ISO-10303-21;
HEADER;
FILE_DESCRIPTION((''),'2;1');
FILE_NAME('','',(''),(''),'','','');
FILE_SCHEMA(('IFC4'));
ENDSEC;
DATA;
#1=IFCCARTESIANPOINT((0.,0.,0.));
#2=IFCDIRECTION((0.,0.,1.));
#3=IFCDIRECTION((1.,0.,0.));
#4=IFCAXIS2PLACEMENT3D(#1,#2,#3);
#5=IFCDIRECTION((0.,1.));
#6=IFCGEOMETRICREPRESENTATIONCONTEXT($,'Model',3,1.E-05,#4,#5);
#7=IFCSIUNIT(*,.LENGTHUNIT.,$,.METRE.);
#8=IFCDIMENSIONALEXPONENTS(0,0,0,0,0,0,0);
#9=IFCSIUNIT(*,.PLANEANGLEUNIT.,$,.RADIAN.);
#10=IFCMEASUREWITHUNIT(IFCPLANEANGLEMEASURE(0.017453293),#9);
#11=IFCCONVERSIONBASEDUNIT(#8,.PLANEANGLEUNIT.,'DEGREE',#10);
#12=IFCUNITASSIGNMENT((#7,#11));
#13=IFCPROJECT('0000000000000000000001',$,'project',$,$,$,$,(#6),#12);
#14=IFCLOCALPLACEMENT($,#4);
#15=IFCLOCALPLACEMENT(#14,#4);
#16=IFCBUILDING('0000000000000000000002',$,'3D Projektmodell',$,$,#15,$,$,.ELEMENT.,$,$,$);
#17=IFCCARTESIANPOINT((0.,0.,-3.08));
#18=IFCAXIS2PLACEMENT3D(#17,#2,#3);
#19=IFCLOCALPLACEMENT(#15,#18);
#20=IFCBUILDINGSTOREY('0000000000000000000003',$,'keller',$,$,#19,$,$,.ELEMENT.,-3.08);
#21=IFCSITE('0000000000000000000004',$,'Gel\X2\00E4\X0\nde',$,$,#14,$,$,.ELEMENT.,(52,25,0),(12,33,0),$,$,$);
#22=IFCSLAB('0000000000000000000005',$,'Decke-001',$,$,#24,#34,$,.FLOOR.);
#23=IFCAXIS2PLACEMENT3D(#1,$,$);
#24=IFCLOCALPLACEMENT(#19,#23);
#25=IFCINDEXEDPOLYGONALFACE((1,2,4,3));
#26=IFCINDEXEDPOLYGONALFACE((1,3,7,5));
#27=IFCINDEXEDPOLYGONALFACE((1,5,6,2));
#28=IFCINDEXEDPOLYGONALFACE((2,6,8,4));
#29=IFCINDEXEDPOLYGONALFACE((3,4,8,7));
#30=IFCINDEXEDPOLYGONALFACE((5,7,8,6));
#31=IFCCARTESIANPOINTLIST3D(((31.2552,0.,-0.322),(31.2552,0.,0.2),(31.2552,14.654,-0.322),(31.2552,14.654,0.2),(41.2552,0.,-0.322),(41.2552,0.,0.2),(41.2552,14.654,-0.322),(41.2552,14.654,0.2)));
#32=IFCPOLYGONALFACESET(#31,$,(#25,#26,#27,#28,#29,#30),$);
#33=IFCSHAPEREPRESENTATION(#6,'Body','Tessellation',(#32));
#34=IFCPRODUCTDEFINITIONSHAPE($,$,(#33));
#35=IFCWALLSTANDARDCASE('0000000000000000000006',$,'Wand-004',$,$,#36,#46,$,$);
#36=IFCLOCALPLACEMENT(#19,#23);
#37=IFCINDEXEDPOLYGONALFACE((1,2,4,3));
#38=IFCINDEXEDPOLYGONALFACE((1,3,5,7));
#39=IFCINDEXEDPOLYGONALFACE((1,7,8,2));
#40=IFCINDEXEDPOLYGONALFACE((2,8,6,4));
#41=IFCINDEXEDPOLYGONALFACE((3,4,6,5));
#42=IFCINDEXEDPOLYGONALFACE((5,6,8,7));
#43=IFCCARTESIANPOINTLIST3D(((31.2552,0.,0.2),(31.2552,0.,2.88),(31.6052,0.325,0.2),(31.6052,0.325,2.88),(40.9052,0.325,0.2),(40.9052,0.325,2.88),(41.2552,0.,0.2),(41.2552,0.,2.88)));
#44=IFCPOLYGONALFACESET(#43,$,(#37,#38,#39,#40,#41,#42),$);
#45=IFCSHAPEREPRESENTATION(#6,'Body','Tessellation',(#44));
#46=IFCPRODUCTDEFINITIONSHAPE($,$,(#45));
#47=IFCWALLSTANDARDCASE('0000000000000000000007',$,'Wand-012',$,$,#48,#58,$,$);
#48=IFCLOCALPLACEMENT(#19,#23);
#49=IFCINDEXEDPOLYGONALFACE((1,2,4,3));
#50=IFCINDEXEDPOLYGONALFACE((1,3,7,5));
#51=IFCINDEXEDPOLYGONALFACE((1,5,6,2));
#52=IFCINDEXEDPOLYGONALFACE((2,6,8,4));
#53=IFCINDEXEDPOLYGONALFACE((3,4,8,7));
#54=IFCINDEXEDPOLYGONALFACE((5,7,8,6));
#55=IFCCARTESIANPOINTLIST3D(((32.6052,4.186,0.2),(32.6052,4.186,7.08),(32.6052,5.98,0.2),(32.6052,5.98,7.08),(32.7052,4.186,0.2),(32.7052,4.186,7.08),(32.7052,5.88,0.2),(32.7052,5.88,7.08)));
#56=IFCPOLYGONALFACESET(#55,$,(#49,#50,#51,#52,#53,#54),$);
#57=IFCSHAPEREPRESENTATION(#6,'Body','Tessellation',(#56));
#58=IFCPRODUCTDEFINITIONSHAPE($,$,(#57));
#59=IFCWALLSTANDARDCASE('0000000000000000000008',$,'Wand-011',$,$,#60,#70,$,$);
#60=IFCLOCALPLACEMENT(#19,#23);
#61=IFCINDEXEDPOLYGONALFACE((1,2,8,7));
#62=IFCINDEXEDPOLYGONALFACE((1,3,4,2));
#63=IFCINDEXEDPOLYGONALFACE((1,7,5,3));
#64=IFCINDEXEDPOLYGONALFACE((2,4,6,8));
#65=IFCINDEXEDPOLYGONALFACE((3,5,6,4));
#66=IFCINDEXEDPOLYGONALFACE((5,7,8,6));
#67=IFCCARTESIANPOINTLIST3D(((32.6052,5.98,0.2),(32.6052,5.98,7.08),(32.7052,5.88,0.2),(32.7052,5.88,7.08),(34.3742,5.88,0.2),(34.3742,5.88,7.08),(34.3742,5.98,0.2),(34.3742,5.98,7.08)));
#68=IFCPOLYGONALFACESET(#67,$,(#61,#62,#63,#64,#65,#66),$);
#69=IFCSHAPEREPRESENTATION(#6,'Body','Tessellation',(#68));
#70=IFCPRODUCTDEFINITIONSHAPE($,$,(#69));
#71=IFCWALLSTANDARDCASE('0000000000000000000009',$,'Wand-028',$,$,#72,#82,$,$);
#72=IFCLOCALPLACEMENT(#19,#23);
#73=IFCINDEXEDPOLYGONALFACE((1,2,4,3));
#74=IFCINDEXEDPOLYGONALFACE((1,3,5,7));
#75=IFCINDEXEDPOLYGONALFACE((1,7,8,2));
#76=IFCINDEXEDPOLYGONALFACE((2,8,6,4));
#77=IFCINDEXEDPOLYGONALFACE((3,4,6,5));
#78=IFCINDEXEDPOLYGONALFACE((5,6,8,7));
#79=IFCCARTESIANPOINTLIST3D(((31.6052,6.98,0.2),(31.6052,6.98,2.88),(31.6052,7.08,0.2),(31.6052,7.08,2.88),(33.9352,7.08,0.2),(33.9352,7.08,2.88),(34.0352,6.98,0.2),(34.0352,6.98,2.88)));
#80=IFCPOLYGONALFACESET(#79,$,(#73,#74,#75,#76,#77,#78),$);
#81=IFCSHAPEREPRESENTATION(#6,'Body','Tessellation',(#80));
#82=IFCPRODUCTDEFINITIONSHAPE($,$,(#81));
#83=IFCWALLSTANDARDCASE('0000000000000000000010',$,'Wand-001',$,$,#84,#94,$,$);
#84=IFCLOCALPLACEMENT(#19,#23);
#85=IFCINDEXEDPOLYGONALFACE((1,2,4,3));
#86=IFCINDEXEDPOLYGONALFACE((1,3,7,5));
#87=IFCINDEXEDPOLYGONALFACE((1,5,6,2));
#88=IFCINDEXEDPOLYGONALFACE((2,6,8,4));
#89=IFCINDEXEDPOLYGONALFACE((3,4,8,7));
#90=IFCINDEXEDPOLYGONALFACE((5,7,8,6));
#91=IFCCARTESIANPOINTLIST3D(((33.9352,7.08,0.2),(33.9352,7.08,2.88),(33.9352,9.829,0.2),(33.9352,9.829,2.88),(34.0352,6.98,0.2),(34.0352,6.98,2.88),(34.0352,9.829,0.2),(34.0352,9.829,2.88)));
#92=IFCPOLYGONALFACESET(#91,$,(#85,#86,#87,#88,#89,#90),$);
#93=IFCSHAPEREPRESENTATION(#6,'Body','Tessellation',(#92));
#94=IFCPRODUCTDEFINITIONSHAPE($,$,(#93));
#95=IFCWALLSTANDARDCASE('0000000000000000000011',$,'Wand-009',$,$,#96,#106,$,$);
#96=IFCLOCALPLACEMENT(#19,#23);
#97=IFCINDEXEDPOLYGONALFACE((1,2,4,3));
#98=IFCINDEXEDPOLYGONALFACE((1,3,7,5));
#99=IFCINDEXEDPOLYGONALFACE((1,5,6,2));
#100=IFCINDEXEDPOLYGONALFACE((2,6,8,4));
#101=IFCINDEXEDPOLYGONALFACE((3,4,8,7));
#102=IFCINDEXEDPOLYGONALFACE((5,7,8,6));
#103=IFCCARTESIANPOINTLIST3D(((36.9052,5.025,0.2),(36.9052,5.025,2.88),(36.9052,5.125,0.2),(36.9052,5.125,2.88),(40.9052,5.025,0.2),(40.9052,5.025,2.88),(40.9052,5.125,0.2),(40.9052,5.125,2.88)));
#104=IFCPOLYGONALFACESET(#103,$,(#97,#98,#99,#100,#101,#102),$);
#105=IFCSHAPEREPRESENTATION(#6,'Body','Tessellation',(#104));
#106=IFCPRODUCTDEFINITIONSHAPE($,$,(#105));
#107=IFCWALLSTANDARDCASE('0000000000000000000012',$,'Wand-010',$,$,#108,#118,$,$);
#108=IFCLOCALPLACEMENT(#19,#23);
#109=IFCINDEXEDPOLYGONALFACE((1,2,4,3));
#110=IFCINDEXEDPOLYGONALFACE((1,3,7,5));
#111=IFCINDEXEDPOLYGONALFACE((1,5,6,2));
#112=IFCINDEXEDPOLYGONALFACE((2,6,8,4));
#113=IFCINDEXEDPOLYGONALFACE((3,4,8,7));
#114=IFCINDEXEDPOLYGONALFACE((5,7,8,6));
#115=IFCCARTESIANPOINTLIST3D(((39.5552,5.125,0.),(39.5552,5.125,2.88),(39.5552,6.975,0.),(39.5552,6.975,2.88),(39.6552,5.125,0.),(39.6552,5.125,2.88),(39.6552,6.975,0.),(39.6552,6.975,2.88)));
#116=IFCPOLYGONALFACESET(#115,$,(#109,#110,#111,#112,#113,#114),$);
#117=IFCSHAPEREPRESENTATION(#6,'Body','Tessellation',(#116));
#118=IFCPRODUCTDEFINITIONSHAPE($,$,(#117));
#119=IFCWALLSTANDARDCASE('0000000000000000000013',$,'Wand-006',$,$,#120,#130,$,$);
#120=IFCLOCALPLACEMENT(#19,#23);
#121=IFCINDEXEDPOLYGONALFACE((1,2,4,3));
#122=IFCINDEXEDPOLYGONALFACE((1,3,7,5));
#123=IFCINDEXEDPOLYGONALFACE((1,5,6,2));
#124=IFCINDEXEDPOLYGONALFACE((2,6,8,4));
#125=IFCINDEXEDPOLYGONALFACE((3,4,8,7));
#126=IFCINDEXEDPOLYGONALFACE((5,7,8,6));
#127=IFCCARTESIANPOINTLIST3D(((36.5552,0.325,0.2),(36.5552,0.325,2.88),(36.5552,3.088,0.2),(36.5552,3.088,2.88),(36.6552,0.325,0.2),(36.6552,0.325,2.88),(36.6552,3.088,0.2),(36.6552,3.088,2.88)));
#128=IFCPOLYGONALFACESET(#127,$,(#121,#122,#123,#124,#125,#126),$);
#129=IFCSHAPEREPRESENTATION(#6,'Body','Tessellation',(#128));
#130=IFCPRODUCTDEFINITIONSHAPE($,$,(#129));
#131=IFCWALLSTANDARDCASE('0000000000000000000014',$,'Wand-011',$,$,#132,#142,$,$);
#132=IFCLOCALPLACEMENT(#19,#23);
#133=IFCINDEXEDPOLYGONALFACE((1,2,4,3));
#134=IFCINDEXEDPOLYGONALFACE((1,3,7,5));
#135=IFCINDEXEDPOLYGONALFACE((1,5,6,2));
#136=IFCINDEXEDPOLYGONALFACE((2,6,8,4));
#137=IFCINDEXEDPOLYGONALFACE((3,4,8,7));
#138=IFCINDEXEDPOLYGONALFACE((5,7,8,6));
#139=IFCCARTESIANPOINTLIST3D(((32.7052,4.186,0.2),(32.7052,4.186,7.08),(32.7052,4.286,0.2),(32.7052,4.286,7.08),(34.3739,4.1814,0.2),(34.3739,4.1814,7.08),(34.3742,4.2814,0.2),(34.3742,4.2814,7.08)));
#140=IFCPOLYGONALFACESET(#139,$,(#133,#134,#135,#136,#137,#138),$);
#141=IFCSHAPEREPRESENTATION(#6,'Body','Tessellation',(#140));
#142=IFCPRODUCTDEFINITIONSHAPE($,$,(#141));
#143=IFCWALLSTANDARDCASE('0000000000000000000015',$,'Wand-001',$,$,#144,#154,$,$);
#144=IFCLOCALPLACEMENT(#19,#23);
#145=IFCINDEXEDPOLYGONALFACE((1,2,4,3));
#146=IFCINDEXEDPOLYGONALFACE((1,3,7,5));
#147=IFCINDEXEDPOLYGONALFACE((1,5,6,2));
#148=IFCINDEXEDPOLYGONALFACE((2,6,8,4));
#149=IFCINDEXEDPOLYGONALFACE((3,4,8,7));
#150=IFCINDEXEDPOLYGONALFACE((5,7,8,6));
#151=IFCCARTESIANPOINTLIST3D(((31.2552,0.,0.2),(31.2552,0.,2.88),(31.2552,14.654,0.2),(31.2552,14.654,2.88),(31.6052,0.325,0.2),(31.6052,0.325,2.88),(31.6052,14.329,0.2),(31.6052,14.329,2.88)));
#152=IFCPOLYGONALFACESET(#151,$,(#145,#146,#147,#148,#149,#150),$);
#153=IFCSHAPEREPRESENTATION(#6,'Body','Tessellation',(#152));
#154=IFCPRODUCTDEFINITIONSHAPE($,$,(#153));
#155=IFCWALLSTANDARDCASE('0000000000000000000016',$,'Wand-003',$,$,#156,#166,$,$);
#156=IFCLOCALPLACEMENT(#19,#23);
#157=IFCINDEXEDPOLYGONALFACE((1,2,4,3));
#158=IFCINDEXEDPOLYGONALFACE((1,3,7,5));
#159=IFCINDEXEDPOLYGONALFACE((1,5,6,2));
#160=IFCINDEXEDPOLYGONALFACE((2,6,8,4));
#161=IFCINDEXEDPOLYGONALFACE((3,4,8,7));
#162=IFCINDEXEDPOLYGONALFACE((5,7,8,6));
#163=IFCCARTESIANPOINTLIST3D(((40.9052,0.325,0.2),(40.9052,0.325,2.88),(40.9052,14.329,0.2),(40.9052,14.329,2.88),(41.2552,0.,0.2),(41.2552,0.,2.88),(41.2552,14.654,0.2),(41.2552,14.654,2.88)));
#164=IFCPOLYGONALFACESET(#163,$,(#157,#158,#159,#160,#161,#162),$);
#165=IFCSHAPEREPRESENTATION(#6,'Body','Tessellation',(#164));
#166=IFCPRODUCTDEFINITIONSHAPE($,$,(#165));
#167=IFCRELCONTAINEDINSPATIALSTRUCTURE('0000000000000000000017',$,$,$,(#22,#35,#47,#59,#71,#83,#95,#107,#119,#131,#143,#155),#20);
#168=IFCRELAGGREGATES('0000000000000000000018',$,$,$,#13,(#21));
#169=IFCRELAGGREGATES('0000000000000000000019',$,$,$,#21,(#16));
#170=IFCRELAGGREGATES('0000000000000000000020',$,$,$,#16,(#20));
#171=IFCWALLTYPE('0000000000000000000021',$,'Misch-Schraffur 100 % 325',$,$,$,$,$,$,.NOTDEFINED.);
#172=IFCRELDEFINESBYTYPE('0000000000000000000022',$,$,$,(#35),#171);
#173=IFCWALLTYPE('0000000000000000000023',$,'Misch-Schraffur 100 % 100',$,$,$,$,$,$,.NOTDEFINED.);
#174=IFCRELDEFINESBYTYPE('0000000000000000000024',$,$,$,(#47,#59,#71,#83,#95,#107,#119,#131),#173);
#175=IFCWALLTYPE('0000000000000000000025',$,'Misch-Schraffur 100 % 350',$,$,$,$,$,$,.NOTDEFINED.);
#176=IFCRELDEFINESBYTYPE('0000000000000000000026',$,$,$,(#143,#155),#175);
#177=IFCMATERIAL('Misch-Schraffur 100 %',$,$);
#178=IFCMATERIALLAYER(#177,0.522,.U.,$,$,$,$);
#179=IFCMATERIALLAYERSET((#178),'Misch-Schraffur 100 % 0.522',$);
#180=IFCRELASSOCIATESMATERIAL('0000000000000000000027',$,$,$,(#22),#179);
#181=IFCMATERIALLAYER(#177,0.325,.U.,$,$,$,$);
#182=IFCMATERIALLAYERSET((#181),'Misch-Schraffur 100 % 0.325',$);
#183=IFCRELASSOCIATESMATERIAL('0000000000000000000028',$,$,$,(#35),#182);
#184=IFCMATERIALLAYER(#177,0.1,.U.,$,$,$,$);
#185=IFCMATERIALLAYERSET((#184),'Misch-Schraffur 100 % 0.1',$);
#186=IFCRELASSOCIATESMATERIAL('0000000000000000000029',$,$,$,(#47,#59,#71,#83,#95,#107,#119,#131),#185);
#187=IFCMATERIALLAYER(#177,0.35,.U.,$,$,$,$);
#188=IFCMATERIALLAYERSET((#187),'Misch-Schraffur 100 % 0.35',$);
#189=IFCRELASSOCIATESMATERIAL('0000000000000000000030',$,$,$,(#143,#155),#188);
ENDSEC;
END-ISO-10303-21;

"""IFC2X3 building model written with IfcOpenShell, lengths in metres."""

from ifc_helpers import new_model, entity, si_unit, converted_unit, direction, frame, origin_with_axes, place, context, project, spatial, polyline, outline, extrude, material, layer, layer_set, layer_usage, type_object, element, save


model = new_model("IFC2X3")

# Units and contexts
model_context = context("Model", 3, precision=1e-05, world=origin_with_axes(), true_north=direction((0.0, 1.0)))
ifc_project = project(units=[si_unit("LENGTHUNIT", "METRE"), converted_unit("PLANEANGLEUNIT", "DEGREE", entity("IfcPlaneAngleMeasure", 0.017453293), si_unit("PLANEANGLEUNIT", "RADIAN"), dimensions=[0, 0, 0, 0, 0, 0, 0])], contexts=[model_context])

# Site, building, storey
site_placement = place(None, origin_with_axes())
site = spatial("IfcSite", under=ifc_project, at=site_placement, Name="Gelände", CompositionType="ELEMENT", RefLatitude=(52, 25, 0), RefLongitude=(12, 33, 0))
building_placement = place(site_placement, origin_with_axes())
building = spatial("IfcBuilding", under=site, at=building_placement, Name="3D Projektmodell", CompositionType="ELEMENT")
storey_placement = place(building_placement, frame((0.0, 0.0, -3.08), z_axis=(0.0, 0.0, 1.0), x_axis=(1.0, 0.0, 0.0)))
storey = spatial("IfcBuildingStorey", under=building, at=storey_placement, Name="keller", CompositionType="ELEMENT", Elevation=-3.08)

# Slab
ifc_material = material(Name="Misch-Schraffur 100 %")
ifc_layer_1 = layer(ifc_material, 0.522, ventilated="UNKNOWN")
ifc_layer_set_1 = layer_set([ifc_layer_1], Name="Misch-Schraffur 100 % 0.522")
ifc_layer_usage_1 = layer_usage(ifc_layer_set_1, "AXIS3", "NEGATIVE", 0.522)
slab_placement = place(storey_placement, frame((31.2552, 0.0, -0.322), z_axis=(0.0, 0.0, 1.0), x_axis=(1.0, 0.0, 0.0)))
element("IfcSlab", 1, at=slab_placement, inside=storey, material=ifc_layer_usage_1, Name="Decke-001", PredefinedType="FLOOR", context=model_context, shape_type="SweptSolid", body=[
    extrude(outline(polyline([(0.0, 0.0), (10.0, 0.0), (10.0, 14.654), (0.0, 14.654), (0.0, 0.0)])), origin_with_axes(), (0.0, 0.0, 1.0), 0.522),
])

# Shared definitions
ifc_layer_2 = layer(ifc_material, 0.325, ventilated="UNKNOWN")
ifc_layer_set_2 = layer_set([ifc_layer_2], Name="Misch-Schraffur 100 % 0.325")
wall_type_1 = type_object("IfcWallType", Name="Misch-Schraffur 100 % 325", PredefinedType="NOTDEFINED")

# Wall
ifc_layer_usage_2 = layer_usage(ifc_layer_set_2, "AXIS2", "NEGATIVE", 0.0)
wall_1_placement = place(storey_placement, frame((41.2552, 0.0, 0.2), z_axis=(0.0, 0.0, 1.0), x_axis=(-1.0, 0.0, 0.0)))
element("IfcWallStandardCase", 2, at=wall_1_placement, inside=storey, type_object=wall_type_1, material=ifc_layer_usage_2, Name="Wand-004", context=model_context, shape_type="SweptSolid", body=[
    extrude(outline(polyline([(0.35, -0.325), (9.65, -0.325), (10.0, 0.0), (0.0, 0.0), (0.35, -0.325)])), origin_with_axes(), (0.0, 0.0, 1.0), 2.68),
])

# Shared definitions
ifc_layer_3 = layer(ifc_material, 0.1, ventilated="UNKNOWN")
ifc_layer_set_3 = layer_set([ifc_layer_3], Name="Misch-Schraffur 100 % 0.1")
wall_type_2 = type_object("IfcWallType", Name="Misch-Schraffur 100 % 100", PredefinedType="NOTDEFINED")

# Walls
ifc_layer_usage_3 = layer_usage(ifc_layer_set_3, "AXIS2", "POSITIVE", 0.0)
wall_2_placement = place(storey_placement, frame((32.6052, 5.98, 0.2), z_axis=(0.0, 0.0, 1.0), x_axis=(0.0, -1.0, 0.0)))
element("IfcWallStandardCase", 3, at=wall_2_placement, inside=storey, type_object=wall_type_2, material=ifc_layer_usage_3, Name="Wand-012", context=model_context, shape_type="SweptSolid", body=[
    extrude(outline(polyline([(0.0, 0.0), (1.794, 0.0), (1.794, 0.1), (0.1, 0.1), (0.0, 0.0)])), origin_with_axes(), (0.0, 0.0, 1.0), 6.88),
])
ifc_layer_usage_4 = layer_usage(ifc_layer_set_3, "AXIS2", "POSITIVE", 0.0)
wall_3_placement = place(storey_placement, frame((34.3742, 5.98, 0.2), z_axis=(0.0, 0.0, 1.0), x_axis=(-1.0, 0.0, 0.0)))
element("IfcWallStandardCase", 4, at=wall_3_placement, inside=storey, type_object=wall_type_2, material=ifc_layer_usage_4, Name="Wand-011", context=model_context, shape_type="SweptSolid", body=[
    extrude(outline(polyline([(0.0, 0.0), (1.769, 0.0), (1.669, 0.1), (0.0, 0.1), (0.0, 0.0)])), origin_with_axes(), (0.0, 0.0, 1.0), 6.88),
])
ifc_layer_usage_5 = layer_usage(ifc_layer_set_3, "AXIS2", "POSITIVE", 0.0)
wall_4_placement = place(storey_placement, frame((31.6052, 6.98, 0.2), z_axis=(0.0, 0.0, 1.0), x_axis=(1.0, 0.0, 0.0)))
element("IfcWallStandardCase", 5, at=wall_4_placement, inside=storey, type_object=wall_type_2, material=ifc_layer_usage_5, Name="Wand-028", context=model_context, shape_type="SweptSolid", body=[
    extrude(outline(polyline([(0.0, 0.0), (2.43, 0.0), (2.33, 0.1), (0.0, 0.1), (0.0, 0.0)])), origin_with_axes(), (0.0, 0.0, 1.0), 2.68),
])
ifc_layer_usage_6 = layer_usage(ifc_layer_set_3, "AXIS2", "NEGATIVE", 0.0)
wall_5_placement = place(storey_placement, frame((33.9352, 6.98, 0.2), z_axis=(0.0, 0.0, 1.0), x_axis=(0.0, 1.0, 0.0)))
element("IfcWallStandardCase", 6, at=wall_5_placement, inside=storey, type_object=wall_type_2, material=ifc_layer_usage_6, Name="Wand-001", context=model_context, shape_type="SweptSolid", body=[
    extrude(outline(polyline([(0.0, -0.1), (2.849, -0.1), (2.849, 0.0), (0.1, 0.0), (0.0, -0.1)])), origin_with_axes(), (0.0, 0.0, 1.0), 2.68),
])
ifc_layer_usage_7 = layer_usage(ifc_layer_set_3, "AXIS2", "NEGATIVE", 0.0)
wall_6_placement = place(storey_placement, frame((36.9052, 5.125, 0.2), z_axis=(0.0, 0.0, 1.0), x_axis=(1.0, 0.0, 0.0)))
element("IfcWallStandardCase", 7, at=wall_6_placement, inside=storey, type_object=wall_type_2, material=ifc_layer_usage_7, Name="Wand-009", context=model_context, shape_type="SweptSolid", body=[
    extrude(outline(polyline([(0.0, -0.1), (4.0, -0.1), (4.0, 0.0), (0.0, 0.0), (0.0, -0.1)])), origin_with_axes(), (0.0, 0.0, 1.0), 2.68),
])
ifc_layer_usage_8 = layer_usage(ifc_layer_set_3, "AXIS2", "POSITIVE", 0.0)
wall_7_placement = place(storey_placement, frame((39.6552, 5.125, 0.0), z_axis=(0.0, 0.0, 1.0), x_axis=(0.0, 1.0, 0.0)))
element("IfcWallStandardCase", 8, at=wall_7_placement, inside=storey, type_object=wall_type_2, material=ifc_layer_usage_8, Name="Wand-010", context=model_context, shape_type="SweptSolid", body=[
    extrude(outline(polyline([(0.0, 0.0), (1.85, 0.0), (1.85, 0.1), (0.0, 0.1), (0.0, 0.0)])), origin_with_axes(), (0.0, 0.0, 1.0), 2.88),
])
ifc_layer_usage_9 = layer_usage(ifc_layer_set_3, "AXIS2", "POSITIVE", 0.0)
wall_8_placement = place(storey_placement, frame((36.5552, 3.088, 0.2), z_axis=(0.0, 0.0, 1.0), x_axis=(0.0, -1.0, 0.0)))
element("IfcWallStandardCase", 9, at=wall_8_placement, inside=storey, type_object=wall_type_2, material=ifc_layer_usage_9, Name="Wand-006", context=model_context, shape_type="SweptSolid", body=[
    extrude(outline(polyline([(0.0, 0.0), (2.763, 0.0), (2.763, 0.1), (0.0, 0.1), (0.0, 0.0)])), origin_with_axes(), (0.0, 0.0, 1.0), 2.68),
])
ifc_layer_usage_10 = layer_usage(ifc_layer_set_3, "AXIS2", "POSITIVE", 0.0)
wall_9_placement = place(storey_placement, frame((34.3742, 4.2814, 0.2), z_axis=(0.0, 0.0, 1.0), x_axis=(-0.999996, 0.002735, 0.0)))
element("IfcWallStandardCase", 10, at=wall_9_placement, inside=storey, type_object=wall_type_2, material=ifc_layer_usage_10, Name="Wand-011", context=model_context, shape_type="SweptSolid", body=[
    extrude(outline(polyline([(0.0, 0.0), (1.669, 0.0), (1.6687, 0.1), (0.0, 0.1), (0.0, 0.0)])), origin_with_axes(), (0.0, 0.0, 1.0), 6.88),
])

# Shared definitions
ifc_layer_4 = layer(ifc_material, 0.35, ventilated="UNKNOWN")
ifc_layer_set_4 = layer_set([ifc_layer_4], Name="Misch-Schraffur 100 % 0.35")
wall_type_3 = type_object("IfcWallType", Name="Misch-Schraffur 100 % 350", PredefinedType="NOTDEFINED")

# Walls
ifc_layer_usage_11 = layer_usage(ifc_layer_set_4, "AXIS2", "NEGATIVE", 0.0)
wall_10_placement = place(storey_placement, frame((31.2552, 0.0, 0.2), z_axis=(0.0, 0.0, 1.0), x_axis=(0.0, 1.0, 0.0)))
element("IfcWallStandardCase", 11, at=wall_10_placement, inside=storey, type_object=wall_type_3, material=ifc_layer_usage_11, Name="Wand-001", context=model_context, shape_type="SweptSolid", body=[
    extrude(outline(polyline([(0.325, -0.35), (14.329, -0.35), (14.654, 0.0), (0.0, 0.0), (0.325, -0.35)])), origin_with_axes(), (0.0, 0.0, 1.0), 2.68),
])
ifc_layer_usage_12 = layer_usage(ifc_layer_set_4, "AXIS2", "NEGATIVE", 0.0)
wall_11_placement = place(storey_placement, frame((41.2552, 14.654, 0.2), z_axis=(0.0, 0.0, 1.0), x_axis=(0.0, -1.0, 0.0)))
element("IfcWallStandardCase", 12, at=wall_11_placement, inside=storey, type_object=wall_type_3, material=ifc_layer_usage_12, Name="Wand-003", context=model_context, shape_type="SweptSolid", body=[
    extrude(outline(polyline([(0.325, -0.35), (14.329, -0.35), (14.654, 0.0), (0.0, 0.0), (0.325, -0.35)])), origin_with_axes(), (0.0, 0.0, 1.0), 2.68),
])

save(model, "model.ifc")
